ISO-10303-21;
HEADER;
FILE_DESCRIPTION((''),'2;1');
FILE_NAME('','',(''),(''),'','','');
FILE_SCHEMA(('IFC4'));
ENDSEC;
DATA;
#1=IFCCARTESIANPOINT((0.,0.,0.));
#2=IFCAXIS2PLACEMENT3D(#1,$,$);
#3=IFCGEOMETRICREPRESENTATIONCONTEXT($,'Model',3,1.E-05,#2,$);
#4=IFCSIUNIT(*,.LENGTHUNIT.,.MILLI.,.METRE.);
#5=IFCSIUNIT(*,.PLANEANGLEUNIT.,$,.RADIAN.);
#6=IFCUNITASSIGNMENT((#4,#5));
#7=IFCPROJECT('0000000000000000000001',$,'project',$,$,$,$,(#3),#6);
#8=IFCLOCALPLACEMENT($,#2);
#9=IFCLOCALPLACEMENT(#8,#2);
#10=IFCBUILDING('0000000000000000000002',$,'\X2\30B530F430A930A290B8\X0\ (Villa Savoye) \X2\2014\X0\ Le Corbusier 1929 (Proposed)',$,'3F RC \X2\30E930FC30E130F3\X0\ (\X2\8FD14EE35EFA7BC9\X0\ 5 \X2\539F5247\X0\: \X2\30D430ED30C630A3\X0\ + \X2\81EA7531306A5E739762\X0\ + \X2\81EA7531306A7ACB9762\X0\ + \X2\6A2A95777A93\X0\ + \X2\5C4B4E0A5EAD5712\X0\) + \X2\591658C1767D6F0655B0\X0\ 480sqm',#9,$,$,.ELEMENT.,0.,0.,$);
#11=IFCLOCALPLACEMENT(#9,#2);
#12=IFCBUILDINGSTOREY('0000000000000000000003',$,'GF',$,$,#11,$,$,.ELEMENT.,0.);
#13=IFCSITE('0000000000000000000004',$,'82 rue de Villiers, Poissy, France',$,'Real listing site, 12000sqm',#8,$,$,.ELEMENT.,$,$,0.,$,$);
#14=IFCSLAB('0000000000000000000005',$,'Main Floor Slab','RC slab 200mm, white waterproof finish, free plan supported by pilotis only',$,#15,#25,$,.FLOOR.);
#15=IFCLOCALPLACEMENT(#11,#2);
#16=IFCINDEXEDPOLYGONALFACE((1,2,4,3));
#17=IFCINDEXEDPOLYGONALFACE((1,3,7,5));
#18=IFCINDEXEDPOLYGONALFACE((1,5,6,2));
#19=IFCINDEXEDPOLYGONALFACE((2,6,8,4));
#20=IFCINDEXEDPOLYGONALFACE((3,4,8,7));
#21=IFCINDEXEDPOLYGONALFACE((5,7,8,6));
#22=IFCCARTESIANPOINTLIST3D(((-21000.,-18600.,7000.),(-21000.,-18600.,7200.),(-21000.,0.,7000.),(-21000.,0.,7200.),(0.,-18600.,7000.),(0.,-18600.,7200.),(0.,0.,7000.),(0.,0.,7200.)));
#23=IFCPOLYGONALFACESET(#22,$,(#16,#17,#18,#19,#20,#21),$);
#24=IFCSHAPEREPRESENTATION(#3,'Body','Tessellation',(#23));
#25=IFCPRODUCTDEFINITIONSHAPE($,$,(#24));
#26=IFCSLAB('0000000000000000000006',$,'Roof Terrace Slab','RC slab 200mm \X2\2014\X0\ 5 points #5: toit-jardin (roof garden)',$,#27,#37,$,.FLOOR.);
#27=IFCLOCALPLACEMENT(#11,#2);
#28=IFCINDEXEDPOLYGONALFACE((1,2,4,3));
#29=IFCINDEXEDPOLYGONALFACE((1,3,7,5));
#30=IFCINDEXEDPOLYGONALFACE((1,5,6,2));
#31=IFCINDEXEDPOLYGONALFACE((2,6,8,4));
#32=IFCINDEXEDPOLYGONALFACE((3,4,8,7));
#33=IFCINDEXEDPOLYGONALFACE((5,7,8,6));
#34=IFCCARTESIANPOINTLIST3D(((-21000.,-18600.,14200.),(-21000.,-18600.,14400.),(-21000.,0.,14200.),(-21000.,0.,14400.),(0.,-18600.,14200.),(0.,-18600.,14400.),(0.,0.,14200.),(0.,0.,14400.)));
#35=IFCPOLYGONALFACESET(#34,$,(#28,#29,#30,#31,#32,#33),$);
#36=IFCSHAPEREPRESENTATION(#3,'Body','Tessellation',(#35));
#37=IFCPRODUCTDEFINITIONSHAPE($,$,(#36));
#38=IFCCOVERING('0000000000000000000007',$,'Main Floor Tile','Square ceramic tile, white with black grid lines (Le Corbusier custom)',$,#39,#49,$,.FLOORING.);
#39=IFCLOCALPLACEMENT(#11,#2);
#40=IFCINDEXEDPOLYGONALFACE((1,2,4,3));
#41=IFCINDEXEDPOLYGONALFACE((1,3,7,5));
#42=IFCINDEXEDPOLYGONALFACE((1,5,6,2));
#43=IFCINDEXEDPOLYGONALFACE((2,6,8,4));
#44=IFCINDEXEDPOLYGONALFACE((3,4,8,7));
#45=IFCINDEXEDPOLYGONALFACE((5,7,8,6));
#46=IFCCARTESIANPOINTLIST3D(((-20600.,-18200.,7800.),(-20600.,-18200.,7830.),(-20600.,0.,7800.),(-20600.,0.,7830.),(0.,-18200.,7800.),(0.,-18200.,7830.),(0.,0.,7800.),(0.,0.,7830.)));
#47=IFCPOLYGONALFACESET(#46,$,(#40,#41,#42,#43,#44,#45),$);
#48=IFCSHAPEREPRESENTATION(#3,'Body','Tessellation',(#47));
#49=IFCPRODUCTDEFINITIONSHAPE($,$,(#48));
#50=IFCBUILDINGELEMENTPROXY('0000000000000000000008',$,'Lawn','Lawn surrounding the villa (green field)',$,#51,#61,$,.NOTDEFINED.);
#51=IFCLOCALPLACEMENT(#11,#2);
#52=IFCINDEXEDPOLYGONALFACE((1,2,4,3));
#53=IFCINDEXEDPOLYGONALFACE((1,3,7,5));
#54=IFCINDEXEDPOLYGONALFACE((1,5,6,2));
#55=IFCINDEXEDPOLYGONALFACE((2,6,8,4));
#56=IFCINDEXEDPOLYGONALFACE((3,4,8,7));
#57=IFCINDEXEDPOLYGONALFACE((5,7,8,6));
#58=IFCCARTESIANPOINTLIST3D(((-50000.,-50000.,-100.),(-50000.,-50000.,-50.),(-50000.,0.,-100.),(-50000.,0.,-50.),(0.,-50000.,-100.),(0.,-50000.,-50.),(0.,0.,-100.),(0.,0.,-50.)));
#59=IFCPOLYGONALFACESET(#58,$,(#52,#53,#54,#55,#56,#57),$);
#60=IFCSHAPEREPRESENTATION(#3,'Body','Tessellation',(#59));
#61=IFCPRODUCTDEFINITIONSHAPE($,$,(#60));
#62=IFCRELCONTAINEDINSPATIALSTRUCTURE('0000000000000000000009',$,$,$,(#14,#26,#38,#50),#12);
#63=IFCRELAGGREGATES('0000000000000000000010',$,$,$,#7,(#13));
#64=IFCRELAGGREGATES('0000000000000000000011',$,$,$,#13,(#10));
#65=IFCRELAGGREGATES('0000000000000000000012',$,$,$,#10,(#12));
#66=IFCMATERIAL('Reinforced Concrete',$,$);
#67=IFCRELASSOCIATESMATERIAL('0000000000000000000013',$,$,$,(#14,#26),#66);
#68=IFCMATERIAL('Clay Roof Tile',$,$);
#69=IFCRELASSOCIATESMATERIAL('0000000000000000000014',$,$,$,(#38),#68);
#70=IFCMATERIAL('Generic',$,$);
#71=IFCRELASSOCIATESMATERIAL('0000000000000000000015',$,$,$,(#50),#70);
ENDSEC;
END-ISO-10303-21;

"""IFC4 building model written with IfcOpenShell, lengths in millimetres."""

from ifc_helpers import new_model, si_unit, frame, frame_2d, origin, place, context, project, spatial, rectangle, extrude, material, element, save


model = new_model("IFC4")

# Units and contexts
model_context = context("Model", 3, precision=1e-05, world=origin())
ifc_project = project(units=[si_unit("LENGTHUNIT", "METRE", prefix="MILLI"), si_unit("PLANEANGLEUNIT", "RADIAN")], contexts=[model_context])

# Site, building, storey
site_placement = place(None, origin())
site = spatial("IfcSite", under=ifc_project, at=site_placement, Name="82 rue de Villiers, Poissy, France", ObjectType="Real listing site, 12000sqm", CompositionType="ELEMENT", RefElevation=0.0)
building_placement = place(site_placement, origin())
building = spatial("IfcBuilding", under=site, at=building_placement, Name="サヴォア邸 (Villa Savoye) — Le Corbusier 1929 (Proposed)", ObjectType="3F RC ラーメン (近代建築 5 原則: ピロティ + 自由な平面 + 自由な立面 + 横長窓 + 屋上庭園) + 外壁白漆喰 480sqm", CompositionType="ELEMENT", ElevationOfRefHeight=0.0, ElevationOfTerrain=0.0)
storey_placement = place(building_placement, origin())
storey = spatial("IfcBuildingStorey", under=building, at=storey_placement, Name="GF", CompositionType="ELEMENT", Elevation=0.0)

# Shared definitions
ifc_material_1 = material(Name="Reinforced Concrete")
ifc_material_2 = material(Name="Generic")

# Slabs
slab_1_placement = place(storey_placement, frame((-10500.0, -9300.0, 3500.0)))
element("IfcSlab", 1, at=slab_1_placement, inside=storey, material=ifc_material_1, Name="Main Floor Slab", Description="RC slab 200mm, white waterproof finish, free plan supported by pilotis only", PredefinedType="FLOOR", context=model_context, shape_type="SweptSolid", body=[
    extrude(rectangle(XDim=21000.0, YDim=18600.0, at=frame_2d((10500.0, 9300.0))), frame((-10500.0, -9300.0, 3500.0)), (0.0, 0.0, 1.0), 200.0),
])
slab_2_placement = place(storey_placement, frame((-10500.0, -9300.0, 7100.0)))
element("IfcSlab", 2, at=slab_2_placement, inside=storey, material=ifc_material_1, Name="Roof Terrace Slab", Description="RC slab 200mm — 5 points #5: toit-jardin (roof garden)", PredefinedType="FLOOR", context=model_context, shape_type="SweptSolid", body=[
    extrude(rectangle(XDim=21000.0, YDim=18600.0, at=frame_2d((10500.0, 9300.0))), frame((-10500.0, -9300.0, 7100.0)), (0.0, 0.0, 1.0), 200.0),
])

# Covering
ifc_material_3 = material(Name="Clay Roof Tile")
covering_placement = place(storey_placement, frame((-10300.0, -9100.0, 3900.0)))
element("IfcCovering", 3, at=covering_placement, inside=storey, material=ifc_material_3, Name="Main Floor Tile", Description="Square ceramic tile, white with black grid lines (Le Corbusier custom)", PredefinedType="FLOORING", context=model_context, shape_type="SweptSolid", body=[
    extrude(rectangle(XDim=20600.0, YDim=18200.0, at=frame_2d((10300.0, 9100.0))), frame((-10300.0, -9100.0, 3900.0)), (0.0, 0.0, 1.0), 30.0),
])

# Building element proxy
proxy_1_placement = place(storey_placement, frame((-25000.0, -25000.0, -50.0)))
element("IfcBuildingElementProxy", 4, at=proxy_1_placement, inside=storey, material=ifc_material_2, Name="Lawn", Description="Lawn surrounding the villa (green field)", PredefinedType="NOTDEFINED", context=model_context, shape_type="SweptSolid", body=[
    extrude(rectangle(XDim=50000.0, YDim=50000.0, at=frame_2d((25000.0, 25000.0))), frame((-25000.0, -25000.0, -50.0)), (0.0, 0.0, 1.0), 50.0),
])

save(model, "model.ifc")
